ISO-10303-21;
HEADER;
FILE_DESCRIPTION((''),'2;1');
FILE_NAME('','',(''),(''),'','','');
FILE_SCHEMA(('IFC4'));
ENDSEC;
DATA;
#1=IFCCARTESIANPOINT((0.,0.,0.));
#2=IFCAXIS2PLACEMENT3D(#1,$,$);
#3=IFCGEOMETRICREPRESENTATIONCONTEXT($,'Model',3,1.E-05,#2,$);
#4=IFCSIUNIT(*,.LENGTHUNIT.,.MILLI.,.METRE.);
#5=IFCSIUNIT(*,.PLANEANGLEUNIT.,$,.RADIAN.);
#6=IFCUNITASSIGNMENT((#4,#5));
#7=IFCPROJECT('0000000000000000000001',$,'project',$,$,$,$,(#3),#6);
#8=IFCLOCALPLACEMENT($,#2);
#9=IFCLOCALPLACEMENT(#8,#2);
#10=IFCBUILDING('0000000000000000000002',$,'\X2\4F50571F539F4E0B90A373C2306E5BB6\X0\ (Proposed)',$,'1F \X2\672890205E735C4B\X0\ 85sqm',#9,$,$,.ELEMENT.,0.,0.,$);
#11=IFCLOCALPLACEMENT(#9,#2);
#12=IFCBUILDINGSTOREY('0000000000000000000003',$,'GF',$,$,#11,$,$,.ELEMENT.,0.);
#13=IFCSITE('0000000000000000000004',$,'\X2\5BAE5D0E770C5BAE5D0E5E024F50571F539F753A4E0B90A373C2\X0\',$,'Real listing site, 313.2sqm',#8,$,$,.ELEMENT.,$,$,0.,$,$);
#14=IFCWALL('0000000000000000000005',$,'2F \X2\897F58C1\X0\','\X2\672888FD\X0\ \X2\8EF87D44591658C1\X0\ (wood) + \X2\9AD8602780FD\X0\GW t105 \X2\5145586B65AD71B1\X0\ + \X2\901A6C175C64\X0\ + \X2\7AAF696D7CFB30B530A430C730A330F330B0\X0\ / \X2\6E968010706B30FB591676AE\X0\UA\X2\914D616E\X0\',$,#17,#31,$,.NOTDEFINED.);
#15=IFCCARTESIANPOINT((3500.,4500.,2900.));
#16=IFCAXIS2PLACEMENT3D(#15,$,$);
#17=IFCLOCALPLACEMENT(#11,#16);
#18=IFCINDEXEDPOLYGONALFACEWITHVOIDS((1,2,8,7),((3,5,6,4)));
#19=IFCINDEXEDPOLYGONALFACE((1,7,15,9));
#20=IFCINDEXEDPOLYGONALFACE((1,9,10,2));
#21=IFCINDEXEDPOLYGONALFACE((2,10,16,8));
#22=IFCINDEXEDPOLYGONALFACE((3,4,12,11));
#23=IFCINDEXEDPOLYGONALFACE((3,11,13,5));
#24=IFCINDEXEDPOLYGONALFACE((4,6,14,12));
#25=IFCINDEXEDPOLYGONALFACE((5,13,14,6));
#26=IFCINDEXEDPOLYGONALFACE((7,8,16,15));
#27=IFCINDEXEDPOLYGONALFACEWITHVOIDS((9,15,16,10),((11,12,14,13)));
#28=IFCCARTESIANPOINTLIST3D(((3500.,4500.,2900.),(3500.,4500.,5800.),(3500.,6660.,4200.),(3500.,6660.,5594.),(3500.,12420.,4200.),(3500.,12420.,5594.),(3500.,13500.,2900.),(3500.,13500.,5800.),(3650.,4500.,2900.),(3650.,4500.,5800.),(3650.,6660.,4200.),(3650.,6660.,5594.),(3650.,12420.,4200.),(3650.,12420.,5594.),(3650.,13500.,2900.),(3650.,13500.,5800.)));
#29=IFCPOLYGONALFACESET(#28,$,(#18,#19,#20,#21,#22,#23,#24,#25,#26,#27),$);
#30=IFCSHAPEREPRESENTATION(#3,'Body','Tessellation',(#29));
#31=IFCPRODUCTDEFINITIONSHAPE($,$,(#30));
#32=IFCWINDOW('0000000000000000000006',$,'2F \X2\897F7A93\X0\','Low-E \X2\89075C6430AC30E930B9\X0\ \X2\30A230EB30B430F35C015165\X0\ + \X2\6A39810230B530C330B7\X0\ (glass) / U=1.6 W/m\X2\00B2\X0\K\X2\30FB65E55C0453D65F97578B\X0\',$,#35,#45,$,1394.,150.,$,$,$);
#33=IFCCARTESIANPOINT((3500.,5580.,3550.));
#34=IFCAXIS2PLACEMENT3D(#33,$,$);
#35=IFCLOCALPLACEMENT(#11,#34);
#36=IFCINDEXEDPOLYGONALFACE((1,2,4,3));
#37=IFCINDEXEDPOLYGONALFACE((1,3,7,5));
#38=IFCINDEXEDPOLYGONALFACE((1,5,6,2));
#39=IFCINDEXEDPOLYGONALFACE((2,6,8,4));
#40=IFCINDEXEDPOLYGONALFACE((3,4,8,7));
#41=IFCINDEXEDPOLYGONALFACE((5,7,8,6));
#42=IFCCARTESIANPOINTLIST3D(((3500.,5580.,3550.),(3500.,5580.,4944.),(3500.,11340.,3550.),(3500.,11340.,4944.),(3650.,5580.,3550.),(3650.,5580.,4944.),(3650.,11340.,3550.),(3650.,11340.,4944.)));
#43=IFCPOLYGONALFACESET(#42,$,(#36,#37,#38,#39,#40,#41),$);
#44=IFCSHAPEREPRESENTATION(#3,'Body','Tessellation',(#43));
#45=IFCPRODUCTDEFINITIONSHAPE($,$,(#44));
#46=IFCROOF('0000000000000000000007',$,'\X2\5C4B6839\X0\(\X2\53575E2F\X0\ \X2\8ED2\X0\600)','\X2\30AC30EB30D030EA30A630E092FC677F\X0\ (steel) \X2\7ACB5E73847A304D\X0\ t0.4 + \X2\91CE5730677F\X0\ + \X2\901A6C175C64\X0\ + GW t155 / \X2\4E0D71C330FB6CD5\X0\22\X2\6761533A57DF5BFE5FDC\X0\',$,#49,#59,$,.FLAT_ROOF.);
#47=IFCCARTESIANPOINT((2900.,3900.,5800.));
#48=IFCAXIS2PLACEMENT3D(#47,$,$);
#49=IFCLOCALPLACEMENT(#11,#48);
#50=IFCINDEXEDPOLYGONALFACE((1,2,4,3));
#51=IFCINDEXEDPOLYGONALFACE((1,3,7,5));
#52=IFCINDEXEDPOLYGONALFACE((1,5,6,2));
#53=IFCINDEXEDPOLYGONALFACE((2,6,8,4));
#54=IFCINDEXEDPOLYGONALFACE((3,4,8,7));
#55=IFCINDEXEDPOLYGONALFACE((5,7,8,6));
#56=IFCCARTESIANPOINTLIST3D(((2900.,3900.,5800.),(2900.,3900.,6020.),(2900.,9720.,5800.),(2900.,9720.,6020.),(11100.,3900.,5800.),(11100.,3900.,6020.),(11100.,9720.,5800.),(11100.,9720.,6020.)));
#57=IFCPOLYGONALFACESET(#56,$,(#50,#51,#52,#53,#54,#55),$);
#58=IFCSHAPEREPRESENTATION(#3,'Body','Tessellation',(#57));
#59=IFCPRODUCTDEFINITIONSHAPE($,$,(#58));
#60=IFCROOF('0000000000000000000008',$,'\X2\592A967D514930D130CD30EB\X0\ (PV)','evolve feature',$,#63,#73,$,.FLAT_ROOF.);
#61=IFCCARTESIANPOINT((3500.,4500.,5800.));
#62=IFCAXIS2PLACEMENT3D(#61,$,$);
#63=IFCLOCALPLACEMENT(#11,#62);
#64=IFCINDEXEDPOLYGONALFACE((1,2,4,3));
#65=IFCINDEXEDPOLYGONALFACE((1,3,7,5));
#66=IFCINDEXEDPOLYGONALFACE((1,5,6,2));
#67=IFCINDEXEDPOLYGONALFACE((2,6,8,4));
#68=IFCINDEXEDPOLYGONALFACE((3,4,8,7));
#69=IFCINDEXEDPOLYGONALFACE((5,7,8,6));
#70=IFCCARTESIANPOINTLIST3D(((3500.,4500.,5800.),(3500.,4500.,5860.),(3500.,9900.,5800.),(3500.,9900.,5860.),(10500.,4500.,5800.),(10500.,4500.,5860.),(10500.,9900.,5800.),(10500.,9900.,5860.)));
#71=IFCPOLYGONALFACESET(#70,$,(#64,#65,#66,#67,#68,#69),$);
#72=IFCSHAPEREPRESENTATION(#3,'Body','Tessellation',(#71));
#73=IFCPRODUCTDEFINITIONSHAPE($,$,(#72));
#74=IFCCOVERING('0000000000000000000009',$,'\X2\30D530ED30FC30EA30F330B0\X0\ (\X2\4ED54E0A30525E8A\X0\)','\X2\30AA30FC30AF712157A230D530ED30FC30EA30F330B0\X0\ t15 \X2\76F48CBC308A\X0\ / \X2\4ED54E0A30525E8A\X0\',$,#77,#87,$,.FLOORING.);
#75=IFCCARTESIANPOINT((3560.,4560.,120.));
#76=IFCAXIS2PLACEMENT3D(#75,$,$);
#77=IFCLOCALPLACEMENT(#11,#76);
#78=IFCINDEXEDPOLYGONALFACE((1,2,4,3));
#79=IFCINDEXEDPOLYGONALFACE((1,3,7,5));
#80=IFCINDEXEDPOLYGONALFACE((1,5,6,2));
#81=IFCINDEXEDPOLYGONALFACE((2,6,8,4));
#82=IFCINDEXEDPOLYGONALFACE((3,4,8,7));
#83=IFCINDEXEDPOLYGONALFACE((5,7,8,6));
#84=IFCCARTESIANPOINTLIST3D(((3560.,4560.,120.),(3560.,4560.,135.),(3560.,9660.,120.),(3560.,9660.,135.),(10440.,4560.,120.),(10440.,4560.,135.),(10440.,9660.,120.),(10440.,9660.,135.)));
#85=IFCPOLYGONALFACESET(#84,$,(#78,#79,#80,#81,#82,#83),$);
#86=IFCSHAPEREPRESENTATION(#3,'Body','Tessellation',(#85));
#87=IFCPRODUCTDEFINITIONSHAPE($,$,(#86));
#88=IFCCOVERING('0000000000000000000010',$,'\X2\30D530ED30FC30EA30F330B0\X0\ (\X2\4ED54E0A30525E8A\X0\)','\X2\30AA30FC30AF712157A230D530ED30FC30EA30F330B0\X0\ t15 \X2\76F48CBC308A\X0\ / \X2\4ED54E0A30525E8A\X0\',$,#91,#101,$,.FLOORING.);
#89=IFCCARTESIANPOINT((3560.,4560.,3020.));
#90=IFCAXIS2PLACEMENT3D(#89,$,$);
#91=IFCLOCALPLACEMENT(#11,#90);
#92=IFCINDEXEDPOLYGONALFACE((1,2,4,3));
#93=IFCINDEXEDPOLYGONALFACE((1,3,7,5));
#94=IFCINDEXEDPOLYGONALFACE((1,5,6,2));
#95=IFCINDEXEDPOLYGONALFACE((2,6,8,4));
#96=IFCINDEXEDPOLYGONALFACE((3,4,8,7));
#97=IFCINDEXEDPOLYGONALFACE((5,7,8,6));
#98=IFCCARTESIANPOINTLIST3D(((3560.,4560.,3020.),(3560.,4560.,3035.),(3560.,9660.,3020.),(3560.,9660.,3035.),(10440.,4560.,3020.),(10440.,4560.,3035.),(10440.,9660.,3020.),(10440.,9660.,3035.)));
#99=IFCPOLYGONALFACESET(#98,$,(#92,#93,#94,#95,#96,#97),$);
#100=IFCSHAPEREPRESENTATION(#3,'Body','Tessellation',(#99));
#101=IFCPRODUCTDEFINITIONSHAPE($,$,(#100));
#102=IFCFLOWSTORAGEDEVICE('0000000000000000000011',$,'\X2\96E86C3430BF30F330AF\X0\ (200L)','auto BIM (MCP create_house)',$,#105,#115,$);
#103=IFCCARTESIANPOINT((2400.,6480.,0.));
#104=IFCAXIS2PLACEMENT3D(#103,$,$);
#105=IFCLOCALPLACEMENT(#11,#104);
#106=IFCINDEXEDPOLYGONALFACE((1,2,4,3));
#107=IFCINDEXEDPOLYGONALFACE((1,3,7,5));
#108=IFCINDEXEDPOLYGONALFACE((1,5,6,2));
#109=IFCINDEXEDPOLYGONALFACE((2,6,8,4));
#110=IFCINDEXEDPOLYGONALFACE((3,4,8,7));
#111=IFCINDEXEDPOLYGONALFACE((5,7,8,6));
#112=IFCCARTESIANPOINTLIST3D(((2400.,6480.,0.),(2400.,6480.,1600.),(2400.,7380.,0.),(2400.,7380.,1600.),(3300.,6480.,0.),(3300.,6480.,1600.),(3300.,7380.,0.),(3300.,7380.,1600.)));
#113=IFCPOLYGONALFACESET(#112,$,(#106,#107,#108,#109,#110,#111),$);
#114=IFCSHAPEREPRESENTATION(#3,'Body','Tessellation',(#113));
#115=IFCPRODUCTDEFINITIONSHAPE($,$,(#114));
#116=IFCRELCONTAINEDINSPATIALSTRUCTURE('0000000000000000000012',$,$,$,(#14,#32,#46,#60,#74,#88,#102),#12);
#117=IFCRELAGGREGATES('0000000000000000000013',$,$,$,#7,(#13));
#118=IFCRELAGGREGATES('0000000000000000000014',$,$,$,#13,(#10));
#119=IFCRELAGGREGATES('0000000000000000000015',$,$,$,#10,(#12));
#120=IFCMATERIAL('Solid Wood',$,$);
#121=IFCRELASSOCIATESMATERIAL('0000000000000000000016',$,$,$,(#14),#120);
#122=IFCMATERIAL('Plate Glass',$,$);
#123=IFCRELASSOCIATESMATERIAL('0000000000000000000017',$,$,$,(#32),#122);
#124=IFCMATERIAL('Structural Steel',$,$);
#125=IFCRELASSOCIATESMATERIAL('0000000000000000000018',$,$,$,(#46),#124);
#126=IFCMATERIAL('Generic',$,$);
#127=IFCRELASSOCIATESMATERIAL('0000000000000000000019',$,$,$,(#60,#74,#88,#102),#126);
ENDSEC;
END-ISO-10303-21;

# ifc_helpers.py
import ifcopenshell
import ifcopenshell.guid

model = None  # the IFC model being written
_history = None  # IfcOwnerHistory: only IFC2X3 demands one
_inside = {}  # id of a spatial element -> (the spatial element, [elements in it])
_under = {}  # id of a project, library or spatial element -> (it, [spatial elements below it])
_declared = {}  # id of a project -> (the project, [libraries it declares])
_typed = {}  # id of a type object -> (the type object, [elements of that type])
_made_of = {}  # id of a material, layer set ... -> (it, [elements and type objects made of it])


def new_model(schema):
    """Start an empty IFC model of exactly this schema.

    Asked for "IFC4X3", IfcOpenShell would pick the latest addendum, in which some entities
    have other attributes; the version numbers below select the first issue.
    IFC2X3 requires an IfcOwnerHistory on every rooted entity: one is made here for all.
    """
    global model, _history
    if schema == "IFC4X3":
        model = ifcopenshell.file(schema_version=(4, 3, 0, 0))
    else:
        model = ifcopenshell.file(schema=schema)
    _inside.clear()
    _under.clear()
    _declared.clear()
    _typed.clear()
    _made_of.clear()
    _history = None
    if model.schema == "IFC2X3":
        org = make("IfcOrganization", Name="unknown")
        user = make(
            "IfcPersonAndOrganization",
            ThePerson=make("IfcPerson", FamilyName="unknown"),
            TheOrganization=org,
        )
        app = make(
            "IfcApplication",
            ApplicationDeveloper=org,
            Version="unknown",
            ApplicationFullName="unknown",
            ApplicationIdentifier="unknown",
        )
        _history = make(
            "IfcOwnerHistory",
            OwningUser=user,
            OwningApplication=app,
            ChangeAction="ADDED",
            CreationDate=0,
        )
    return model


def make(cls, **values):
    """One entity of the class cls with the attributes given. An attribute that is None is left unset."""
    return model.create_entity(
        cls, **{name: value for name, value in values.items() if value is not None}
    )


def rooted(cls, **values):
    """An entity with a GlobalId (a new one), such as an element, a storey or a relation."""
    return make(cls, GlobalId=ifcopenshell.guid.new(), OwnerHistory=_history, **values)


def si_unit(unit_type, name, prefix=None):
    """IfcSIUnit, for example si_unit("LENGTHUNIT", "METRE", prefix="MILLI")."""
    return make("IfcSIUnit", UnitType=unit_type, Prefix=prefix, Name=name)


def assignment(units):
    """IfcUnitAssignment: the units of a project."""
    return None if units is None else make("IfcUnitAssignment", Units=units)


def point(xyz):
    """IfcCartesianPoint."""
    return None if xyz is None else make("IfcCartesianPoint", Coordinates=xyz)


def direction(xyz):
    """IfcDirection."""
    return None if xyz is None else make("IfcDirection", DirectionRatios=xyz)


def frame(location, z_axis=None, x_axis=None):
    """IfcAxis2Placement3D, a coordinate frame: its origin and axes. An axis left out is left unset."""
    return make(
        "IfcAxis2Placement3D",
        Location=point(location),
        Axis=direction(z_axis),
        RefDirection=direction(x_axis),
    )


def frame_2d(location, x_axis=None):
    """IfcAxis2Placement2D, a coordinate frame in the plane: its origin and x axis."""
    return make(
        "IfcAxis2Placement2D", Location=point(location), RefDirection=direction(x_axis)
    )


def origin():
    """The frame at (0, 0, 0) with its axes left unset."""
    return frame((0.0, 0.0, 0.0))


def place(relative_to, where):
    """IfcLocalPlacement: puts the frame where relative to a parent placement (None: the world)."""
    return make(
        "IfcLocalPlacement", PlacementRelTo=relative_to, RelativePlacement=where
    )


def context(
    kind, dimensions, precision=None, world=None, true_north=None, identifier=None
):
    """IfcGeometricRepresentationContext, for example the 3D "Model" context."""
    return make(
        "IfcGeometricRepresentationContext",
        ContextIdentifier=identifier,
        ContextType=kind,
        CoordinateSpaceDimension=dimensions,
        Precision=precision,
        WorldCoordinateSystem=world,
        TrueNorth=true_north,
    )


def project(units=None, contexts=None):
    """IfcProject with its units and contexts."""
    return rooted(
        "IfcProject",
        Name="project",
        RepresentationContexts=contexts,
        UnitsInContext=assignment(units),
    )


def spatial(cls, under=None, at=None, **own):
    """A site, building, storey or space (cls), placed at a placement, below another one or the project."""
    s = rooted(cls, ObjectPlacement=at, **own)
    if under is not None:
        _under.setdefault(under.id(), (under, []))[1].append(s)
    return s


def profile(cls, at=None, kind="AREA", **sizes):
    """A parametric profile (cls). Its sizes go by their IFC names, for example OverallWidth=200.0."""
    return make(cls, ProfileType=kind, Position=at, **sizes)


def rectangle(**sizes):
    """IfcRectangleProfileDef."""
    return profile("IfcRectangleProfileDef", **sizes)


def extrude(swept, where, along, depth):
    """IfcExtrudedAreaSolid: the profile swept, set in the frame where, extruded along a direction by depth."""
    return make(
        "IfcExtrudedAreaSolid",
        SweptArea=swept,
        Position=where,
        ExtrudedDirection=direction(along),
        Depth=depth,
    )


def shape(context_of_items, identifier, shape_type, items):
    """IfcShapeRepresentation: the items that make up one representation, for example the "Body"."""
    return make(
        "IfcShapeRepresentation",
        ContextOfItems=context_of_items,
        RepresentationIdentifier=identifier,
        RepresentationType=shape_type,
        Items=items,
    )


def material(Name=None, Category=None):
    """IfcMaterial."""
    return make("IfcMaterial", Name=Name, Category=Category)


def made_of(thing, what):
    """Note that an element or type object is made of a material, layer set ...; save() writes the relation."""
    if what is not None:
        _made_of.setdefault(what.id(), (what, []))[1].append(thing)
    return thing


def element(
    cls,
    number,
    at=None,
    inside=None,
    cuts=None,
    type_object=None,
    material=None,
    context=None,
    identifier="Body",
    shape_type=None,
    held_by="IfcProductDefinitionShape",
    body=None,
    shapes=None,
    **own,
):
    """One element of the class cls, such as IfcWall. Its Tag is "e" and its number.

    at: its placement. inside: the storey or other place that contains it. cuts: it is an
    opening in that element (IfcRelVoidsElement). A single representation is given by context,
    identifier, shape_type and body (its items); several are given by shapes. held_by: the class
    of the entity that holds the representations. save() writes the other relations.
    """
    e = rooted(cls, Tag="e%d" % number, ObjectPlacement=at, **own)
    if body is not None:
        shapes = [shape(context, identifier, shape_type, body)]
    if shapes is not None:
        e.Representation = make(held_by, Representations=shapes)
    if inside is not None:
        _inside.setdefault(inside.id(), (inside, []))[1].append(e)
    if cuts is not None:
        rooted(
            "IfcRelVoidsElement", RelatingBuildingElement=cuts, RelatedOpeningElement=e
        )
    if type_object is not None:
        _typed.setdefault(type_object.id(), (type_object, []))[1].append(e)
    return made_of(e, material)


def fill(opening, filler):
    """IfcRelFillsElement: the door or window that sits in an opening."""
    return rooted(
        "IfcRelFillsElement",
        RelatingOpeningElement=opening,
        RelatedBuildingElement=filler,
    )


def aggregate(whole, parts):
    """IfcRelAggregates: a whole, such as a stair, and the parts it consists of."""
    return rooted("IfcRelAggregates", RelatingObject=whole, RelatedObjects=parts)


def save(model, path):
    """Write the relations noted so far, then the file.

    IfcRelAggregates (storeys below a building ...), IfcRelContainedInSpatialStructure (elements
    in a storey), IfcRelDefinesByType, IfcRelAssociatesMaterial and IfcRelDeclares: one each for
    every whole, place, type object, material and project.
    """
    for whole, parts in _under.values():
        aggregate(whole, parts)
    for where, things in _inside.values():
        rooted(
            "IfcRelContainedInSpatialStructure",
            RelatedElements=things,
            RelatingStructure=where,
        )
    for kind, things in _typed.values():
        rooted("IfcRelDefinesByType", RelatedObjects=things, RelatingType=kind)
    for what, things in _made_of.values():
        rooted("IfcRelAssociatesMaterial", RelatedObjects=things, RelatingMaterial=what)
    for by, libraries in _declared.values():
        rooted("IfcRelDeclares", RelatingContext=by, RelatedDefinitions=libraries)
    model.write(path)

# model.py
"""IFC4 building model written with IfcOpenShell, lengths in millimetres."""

from ifc_helpers import new_model, si_unit, frame, frame_2d, origin, place, context, project, spatial, rectangle, extrude, material, element, fill, save


model = new_model("IFC4")

# Units and contexts
model_context = context("Model", 3, precision=1e-05, world=origin())
ifc_project = project(units=[si_unit("LENGTHUNIT", "METRE", prefix="MILLI"), si_unit("PLANEANGLEUNIT", "RADIAN")], contexts=[model_context])

# Site, building, storey
site_placement = place(None, origin())
site = spatial("IfcSite", under=ifc_project, at=site_placement, Name="宮崎県宮崎市佐土原町下那珂", ObjectType="Real listing site, 313.2sqm", CompositionType="ELEMENT", RefElevation=0.0)
building_placement = place(site_placement, origin())
building = spatial("IfcBuilding", under=site, at=building_placement, Name="佐土原下那珂の家 (Proposed)", ObjectType="1F 木造平屋 85sqm", CompositionType="ELEMENT", ElevationOfRefHeight=0.0, ElevationOfTerrain=0.0)
storey_placement = place(building_placement, origin())
storey = spatial("IfcBuildingStorey", under=building, at=storey_placement, Name="GF", CompositionType="ELEMENT", Elevation=0.0)

# Shared definitions
ifc_material_1 = material(Name="Solid Wood")
ifc_material_2 = material(Name="Generic")

# Shared definitions
ifc_material_3 = material(Name="Plate Glass")

# Wall, opening, window
wall_1_placement = place(storey_placement, frame((3500.0, 4500.0, 2900.0)))
wall_1 = element("IfcWall", 1, at=wall_1_placement, inside=storey, material=ifc_material_1, Name="2F 西壁", Description="木製 軸組外壁 (wood) + 高性能GW t105 充填断熱 + 通気層 + 窯業系サイディング / 準耐火・外皮UA配慮", PredefinedType="NOTDEFINED", context=model_context, shape_type="SweptSolid", body=[
    extrude(rectangle(XDim=150.0, YDim=9000.0, at=frame_2d((75.0, 4500.0))), frame((3500.0, 4500.0, 2900.0)), (0.0, 0.0, 1.0), 2900.0),
])
opening_1_placement = place(storey_placement, frame((3500.0, 5580.0, 3550.0)))
opening_1 = element("IfcOpeningElement", 2, at=opening_1_placement, cuts=wall_1, PredefinedType="NOTDEFINED", context=model_context, shape_type="SweptSolid", body=[
    extrude(rectangle(XDim=150.0, YDim=5760.0, at=frame_2d((75.0, 2880.0))), frame((3500.0, 5580.0, 3550.0)), (0.0, 0.0, 1.0), 1394.0),
])
window_1_placement = place(storey_placement, frame((3500.0, 5580.0, 3550.0)))
window_1 = element("IfcWindow", 3, at=window_1_placement, inside=storey, material=ifc_material_3, Name="2F 西窓", Description="Low-E 複層ガラス アルゴン封入 + 樹脂サッシ (glass) / U=1.6 W/m²K・日射取得型", OverallHeight=1394.0, OverallWidth=150.0, context=model_context, shape_type="SweptSolid", body=[
    extrude(rectangle(XDim=150.0, YDim=5760.0, at=frame_2d((75.0, 2880.0))), frame((3500.0, 5580.0, 3550.0)), (0.0, 0.0, 1.0), 1394.0),
])
fill(opening_1, window_1)

# Roofs
ifc_material_4 = material(Name="Structural Steel")
for number, where, name in (
    (4, (2900.0, 3900.0, 5800.0), "屋根(南帯 軒600)"),
):
    element("IfcRoof", number, at=place(storey_placement, frame(where)), inside=storey, material=ifc_material_4, Name=name, Description="ガルバリウム鋼板 (steel) 立平葺き t0.4 + 野地板 + 通気層 + GW t155 / 不燃・法22条区域対応", PredefinedType="FLAT_ROOF", context=model_context, shape_type="SweptSolid", body=[
        extrude(rectangle(XDim=8200.0, YDim=5820.0, at=frame_2d((4100.0, 2910.0))), frame((2900.0, 3900.0, 5800.0)), (0.0, 0.0, 1.0), 220.0),
    ])
roof_placement = place(storey_placement, frame((3500.0, 4500.0, 5800.0)))
element("IfcRoof", 5, at=roof_placement, inside=storey, material=ifc_material_2, Name="太陽光パネル (PV)", Description="evolve feature", PredefinedType="FLAT_ROOF", context=model_context, shape_type="SweptSolid", body=[
    extrude(rectangle(XDim=7000.0, YDim=5400.0, at=frame_2d((3500.0, 2700.0))), frame((3500.0, 4500.0, 5800.0)), (0.0, 0.0, 1.0), 60.0),
])

# Coverings
covering_1_placement = place(storey_placement, frame((3560.0, 4560.0, 120.0)))
element("IfcCovering", 6, at=covering_1_placement, inside=storey, material=ifc_material_2, Name="フローリング (仕上げ床)", Description="オーク無垢フローリング t15 直貼り / 仕上げ床", PredefinedType="FLOORING", context=model_context, shape_type="SweptSolid", body=[
    extrude(rectangle(XDim=6880.0, YDim=5100.0, at=frame_2d((3440.0, 2550.0))), frame((3560.0, 4560.0, 120.0)), (0.0, 0.0, 1.0), 15.0),
])
covering_2_placement = place(storey_placement, frame((3560.0, 4560.0, 3020.0)))
element("IfcCovering", 7, at=covering_2_placement, inside=storey, material=ifc_material_2, Name="フローリング (仕上げ床)", Description="オーク無垢フローリング t15 直貼り / 仕上げ床", PredefinedType="FLOORING", context=model_context, shape_type="SweptSolid", body=[
    extrude(rectangle(XDim=6880.0, YDim=5100.0, at=frame_2d((3440.0, 2550.0))), frame((3560.0, 4560.0, 3020.0)), (0.0, 0.0, 1.0), 15.0),
])

# Flow storage device
flow_storage_device_placement = place(storey_placement, frame((2400.0, 6480.0, 0.0)))
element("IfcFlowStorageDevice", 8, at=flow_storage_device_placement, inside=storey, material=ifc_material_2, Name="雨水タンク (200L)", Description="auto BIM (MCP create_house)", context=model_context, shape_type="SweptSolid", body=[
    extrude(rectangle(XDim=900.0, YDim=900.0, at=frame_2d((450.0, 450.0))), frame((2400.0, 6480.0, 0.0)), (0.0, 0.0, 1.0), 1600.0),
])

save(model, "model.ifc")
